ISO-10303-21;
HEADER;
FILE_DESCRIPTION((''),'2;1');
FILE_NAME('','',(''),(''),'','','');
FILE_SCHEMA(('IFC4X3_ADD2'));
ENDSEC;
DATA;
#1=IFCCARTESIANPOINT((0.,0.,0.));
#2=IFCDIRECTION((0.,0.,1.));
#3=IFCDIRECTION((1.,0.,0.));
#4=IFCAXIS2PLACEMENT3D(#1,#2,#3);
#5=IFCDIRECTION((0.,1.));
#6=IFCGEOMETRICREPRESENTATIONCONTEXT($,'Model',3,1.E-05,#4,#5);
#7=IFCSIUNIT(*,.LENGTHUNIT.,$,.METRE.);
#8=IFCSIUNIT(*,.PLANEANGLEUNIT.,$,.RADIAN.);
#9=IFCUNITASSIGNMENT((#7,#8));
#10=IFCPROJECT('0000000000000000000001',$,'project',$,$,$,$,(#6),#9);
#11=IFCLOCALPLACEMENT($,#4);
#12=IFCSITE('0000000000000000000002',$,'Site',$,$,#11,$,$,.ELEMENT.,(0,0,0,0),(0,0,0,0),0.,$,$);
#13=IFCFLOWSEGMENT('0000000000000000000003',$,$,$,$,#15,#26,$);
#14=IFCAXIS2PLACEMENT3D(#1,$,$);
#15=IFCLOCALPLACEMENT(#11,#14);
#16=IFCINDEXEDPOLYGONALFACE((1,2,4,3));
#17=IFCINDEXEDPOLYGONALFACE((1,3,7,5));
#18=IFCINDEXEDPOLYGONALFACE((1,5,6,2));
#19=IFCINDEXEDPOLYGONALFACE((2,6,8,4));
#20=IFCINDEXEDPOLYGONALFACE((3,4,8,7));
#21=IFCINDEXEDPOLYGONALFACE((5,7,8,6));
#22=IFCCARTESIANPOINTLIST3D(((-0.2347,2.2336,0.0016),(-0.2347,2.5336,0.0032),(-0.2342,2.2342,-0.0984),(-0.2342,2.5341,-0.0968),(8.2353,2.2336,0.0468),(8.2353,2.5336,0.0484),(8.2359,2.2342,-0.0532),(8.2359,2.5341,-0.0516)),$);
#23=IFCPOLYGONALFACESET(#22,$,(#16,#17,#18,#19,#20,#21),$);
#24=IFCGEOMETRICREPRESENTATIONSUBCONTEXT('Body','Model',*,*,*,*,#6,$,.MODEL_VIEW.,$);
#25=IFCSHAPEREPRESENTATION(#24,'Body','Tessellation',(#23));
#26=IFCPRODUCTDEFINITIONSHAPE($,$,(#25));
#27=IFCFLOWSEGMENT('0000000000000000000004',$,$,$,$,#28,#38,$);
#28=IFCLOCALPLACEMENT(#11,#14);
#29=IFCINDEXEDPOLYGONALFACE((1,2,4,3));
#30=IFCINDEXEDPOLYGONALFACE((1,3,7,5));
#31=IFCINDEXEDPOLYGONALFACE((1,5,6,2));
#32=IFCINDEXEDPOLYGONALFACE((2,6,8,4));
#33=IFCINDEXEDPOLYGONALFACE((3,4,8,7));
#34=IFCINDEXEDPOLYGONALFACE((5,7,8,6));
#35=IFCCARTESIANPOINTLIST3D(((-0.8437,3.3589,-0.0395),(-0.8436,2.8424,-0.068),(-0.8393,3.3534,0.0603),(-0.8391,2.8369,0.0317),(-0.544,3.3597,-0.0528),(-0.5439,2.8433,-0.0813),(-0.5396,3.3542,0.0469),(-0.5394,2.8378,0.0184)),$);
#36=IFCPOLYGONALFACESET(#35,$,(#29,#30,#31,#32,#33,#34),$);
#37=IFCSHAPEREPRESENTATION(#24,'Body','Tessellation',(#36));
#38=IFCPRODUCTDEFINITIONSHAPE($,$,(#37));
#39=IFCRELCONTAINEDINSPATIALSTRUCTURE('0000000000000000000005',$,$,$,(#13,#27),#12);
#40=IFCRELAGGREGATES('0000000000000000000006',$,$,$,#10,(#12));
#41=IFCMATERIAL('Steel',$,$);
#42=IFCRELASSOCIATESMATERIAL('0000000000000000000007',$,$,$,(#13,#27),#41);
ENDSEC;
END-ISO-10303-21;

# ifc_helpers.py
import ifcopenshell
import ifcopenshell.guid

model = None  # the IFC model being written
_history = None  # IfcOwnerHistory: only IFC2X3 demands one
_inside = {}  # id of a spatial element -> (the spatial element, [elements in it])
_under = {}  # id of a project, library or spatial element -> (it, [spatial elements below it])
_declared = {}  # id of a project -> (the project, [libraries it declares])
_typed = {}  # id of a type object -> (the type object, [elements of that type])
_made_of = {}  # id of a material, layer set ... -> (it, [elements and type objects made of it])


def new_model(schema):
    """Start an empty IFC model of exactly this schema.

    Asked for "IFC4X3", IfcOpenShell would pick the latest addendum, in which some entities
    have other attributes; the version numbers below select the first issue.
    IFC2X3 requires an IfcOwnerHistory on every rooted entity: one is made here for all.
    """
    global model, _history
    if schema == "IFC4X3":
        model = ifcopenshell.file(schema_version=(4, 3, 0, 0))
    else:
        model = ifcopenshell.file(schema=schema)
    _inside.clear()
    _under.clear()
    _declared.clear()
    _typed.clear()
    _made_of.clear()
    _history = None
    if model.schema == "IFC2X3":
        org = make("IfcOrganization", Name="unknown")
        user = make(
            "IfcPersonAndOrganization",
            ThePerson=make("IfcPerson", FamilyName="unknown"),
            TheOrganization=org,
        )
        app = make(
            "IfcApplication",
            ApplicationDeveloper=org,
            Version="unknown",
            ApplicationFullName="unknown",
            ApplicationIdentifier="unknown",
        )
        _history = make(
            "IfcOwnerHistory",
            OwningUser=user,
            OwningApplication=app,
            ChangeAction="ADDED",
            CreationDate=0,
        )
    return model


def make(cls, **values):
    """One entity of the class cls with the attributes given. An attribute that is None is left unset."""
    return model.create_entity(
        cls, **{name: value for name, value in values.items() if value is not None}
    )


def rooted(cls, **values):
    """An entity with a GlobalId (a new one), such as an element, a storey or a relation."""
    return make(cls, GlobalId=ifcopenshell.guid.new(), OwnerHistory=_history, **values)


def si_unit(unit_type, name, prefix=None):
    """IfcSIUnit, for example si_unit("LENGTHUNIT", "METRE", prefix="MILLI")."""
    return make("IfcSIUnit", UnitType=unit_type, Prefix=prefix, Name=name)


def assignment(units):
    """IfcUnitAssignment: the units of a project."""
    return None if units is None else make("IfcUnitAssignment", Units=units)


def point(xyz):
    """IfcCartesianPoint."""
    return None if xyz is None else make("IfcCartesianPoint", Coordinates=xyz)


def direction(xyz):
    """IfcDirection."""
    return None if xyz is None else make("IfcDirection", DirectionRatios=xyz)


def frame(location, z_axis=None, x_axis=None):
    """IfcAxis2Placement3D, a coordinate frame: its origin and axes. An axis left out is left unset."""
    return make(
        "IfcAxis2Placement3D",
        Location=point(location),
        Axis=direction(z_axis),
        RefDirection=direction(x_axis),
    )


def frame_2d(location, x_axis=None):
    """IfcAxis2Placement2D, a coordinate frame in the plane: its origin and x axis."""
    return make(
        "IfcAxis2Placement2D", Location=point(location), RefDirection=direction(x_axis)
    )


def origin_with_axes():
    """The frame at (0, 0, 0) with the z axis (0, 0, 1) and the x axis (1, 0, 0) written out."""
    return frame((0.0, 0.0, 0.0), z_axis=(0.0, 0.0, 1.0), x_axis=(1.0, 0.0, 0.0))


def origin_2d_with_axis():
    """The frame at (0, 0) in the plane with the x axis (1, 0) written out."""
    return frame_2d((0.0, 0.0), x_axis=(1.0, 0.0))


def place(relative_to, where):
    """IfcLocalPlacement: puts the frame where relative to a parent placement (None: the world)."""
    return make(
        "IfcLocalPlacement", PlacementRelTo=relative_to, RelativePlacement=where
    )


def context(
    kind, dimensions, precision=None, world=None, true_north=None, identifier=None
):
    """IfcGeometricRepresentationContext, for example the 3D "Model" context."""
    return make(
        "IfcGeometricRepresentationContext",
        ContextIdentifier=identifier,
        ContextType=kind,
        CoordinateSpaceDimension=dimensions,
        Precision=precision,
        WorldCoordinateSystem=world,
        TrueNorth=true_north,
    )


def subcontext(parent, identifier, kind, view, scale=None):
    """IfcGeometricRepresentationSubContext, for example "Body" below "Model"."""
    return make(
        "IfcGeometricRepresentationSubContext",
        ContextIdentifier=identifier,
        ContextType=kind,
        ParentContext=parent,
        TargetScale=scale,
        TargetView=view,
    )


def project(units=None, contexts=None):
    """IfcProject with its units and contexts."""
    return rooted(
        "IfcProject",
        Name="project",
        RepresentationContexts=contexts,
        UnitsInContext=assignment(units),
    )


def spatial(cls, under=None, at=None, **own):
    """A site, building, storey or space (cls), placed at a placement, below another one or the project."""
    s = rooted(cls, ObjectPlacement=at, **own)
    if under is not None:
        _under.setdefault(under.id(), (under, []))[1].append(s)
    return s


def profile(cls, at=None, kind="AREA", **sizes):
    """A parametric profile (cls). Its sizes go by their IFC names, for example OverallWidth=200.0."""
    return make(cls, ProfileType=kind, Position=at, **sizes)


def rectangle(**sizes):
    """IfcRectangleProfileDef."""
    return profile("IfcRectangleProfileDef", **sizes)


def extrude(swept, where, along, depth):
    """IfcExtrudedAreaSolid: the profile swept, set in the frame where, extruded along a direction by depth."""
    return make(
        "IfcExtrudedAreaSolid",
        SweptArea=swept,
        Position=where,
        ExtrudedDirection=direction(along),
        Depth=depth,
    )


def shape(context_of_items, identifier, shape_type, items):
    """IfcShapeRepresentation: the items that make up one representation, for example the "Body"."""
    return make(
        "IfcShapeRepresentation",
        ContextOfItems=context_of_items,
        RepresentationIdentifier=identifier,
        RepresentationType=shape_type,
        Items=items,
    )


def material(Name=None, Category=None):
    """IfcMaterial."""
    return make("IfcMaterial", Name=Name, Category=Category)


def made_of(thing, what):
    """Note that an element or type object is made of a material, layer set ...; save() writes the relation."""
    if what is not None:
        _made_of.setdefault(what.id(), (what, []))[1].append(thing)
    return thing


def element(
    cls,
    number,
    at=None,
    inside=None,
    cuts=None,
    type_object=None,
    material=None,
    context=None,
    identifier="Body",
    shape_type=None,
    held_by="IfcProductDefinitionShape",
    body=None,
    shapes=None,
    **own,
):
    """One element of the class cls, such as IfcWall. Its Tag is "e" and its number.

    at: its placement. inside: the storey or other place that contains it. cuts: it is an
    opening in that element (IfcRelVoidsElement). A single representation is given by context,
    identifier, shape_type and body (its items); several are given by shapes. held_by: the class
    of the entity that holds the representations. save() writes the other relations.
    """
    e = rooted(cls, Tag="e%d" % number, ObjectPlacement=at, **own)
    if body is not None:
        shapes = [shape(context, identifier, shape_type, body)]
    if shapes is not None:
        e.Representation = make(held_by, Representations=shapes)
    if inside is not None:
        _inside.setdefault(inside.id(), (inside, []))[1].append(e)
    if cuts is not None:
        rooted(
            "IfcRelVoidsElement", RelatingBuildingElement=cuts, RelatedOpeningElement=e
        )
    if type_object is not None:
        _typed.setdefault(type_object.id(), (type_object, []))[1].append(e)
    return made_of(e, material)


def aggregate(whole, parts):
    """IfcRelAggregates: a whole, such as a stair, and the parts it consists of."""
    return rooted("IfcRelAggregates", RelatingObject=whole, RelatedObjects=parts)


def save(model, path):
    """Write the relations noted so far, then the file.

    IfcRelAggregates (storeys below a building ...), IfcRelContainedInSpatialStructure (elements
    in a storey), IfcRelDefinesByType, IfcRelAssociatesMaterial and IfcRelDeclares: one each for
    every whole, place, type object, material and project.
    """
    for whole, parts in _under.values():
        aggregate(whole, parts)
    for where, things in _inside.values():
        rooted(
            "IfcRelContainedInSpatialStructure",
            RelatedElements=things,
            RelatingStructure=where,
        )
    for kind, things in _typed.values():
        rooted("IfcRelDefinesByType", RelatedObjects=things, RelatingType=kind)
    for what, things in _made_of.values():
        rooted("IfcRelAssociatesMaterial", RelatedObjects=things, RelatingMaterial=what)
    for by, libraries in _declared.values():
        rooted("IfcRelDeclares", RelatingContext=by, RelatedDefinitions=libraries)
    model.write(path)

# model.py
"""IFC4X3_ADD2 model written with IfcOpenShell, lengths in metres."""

from ifc_helpers import new_model, si_unit, direction, frame, origin_with_axes, origin_2d_with_axis, place, context, subcontext, project, spatial, rectangle, extrude, material, element, save


model = new_model("IFC4X3_ADD2")

# Units and contexts
model_context = context("Model", 3, precision=1e-05, world=origin_with_axes(), true_north=direction((0.0, 1.0)))
body_context = subcontext(model_context, "Body", "Model", "MODEL_VIEW")
ifc_project = project(units=[si_unit("LENGTHUNIT", "METRE"), si_unit("PLANEANGLEUNIT", "RADIAN")], contexts=[model_context])

# Site
site_placement = place(None, origin_with_axes())
site = spatial("IfcSite", under=ifc_project, at=site_placement, Name="Site", CompositionType="ELEMENT", RefLatitude=(0, 0, 0, 0), RefLongitude=(0, 0, 0, 0), RefElevation=0.0)

# Shared definitions
ifc_material = material(Name="Steel")

# Flow segments
flow_segment_1_placement = place(site_placement, frame((8.2356, 2.3839, -0.0024), z_axis=(-0.999986, 0.0, -0.005332), x_axis=(0.000028, -0.999986, -0.005332)))
element("IfcFlowSegment", 1, at=flow_segment_1_placement, inside=site, material=ifc_material, context=body_context, shape_type="SweptSolid", body=[
    extrude(rectangle(XDim=0.3, YDim=0.1, at=origin_2d_with_axis()), origin_with_axes(), (0.0, 0.0, 1.0), 8.4702),
])
flow_segment_2_placement = place(site_placement, frame((-0.6915, 2.8401, -0.0248), z_axis=(-0.000294, 0.998479, 0.055141), x_axis=(-0.999009, -0.002747, 0.044416)))
element("IfcFlowSegment", 2, at=flow_segment_2_placement, inside=site, material=ifc_material, context=body_context, shape_type="SweptSolid", body=[
    extrude(rectangle(XDim=0.3, YDim=0.1, at=origin_2d_with_axis()), origin_with_axes(), (0.0, 0.0, 1.0), 0.5172),
])

save(model, "model.ifc")
